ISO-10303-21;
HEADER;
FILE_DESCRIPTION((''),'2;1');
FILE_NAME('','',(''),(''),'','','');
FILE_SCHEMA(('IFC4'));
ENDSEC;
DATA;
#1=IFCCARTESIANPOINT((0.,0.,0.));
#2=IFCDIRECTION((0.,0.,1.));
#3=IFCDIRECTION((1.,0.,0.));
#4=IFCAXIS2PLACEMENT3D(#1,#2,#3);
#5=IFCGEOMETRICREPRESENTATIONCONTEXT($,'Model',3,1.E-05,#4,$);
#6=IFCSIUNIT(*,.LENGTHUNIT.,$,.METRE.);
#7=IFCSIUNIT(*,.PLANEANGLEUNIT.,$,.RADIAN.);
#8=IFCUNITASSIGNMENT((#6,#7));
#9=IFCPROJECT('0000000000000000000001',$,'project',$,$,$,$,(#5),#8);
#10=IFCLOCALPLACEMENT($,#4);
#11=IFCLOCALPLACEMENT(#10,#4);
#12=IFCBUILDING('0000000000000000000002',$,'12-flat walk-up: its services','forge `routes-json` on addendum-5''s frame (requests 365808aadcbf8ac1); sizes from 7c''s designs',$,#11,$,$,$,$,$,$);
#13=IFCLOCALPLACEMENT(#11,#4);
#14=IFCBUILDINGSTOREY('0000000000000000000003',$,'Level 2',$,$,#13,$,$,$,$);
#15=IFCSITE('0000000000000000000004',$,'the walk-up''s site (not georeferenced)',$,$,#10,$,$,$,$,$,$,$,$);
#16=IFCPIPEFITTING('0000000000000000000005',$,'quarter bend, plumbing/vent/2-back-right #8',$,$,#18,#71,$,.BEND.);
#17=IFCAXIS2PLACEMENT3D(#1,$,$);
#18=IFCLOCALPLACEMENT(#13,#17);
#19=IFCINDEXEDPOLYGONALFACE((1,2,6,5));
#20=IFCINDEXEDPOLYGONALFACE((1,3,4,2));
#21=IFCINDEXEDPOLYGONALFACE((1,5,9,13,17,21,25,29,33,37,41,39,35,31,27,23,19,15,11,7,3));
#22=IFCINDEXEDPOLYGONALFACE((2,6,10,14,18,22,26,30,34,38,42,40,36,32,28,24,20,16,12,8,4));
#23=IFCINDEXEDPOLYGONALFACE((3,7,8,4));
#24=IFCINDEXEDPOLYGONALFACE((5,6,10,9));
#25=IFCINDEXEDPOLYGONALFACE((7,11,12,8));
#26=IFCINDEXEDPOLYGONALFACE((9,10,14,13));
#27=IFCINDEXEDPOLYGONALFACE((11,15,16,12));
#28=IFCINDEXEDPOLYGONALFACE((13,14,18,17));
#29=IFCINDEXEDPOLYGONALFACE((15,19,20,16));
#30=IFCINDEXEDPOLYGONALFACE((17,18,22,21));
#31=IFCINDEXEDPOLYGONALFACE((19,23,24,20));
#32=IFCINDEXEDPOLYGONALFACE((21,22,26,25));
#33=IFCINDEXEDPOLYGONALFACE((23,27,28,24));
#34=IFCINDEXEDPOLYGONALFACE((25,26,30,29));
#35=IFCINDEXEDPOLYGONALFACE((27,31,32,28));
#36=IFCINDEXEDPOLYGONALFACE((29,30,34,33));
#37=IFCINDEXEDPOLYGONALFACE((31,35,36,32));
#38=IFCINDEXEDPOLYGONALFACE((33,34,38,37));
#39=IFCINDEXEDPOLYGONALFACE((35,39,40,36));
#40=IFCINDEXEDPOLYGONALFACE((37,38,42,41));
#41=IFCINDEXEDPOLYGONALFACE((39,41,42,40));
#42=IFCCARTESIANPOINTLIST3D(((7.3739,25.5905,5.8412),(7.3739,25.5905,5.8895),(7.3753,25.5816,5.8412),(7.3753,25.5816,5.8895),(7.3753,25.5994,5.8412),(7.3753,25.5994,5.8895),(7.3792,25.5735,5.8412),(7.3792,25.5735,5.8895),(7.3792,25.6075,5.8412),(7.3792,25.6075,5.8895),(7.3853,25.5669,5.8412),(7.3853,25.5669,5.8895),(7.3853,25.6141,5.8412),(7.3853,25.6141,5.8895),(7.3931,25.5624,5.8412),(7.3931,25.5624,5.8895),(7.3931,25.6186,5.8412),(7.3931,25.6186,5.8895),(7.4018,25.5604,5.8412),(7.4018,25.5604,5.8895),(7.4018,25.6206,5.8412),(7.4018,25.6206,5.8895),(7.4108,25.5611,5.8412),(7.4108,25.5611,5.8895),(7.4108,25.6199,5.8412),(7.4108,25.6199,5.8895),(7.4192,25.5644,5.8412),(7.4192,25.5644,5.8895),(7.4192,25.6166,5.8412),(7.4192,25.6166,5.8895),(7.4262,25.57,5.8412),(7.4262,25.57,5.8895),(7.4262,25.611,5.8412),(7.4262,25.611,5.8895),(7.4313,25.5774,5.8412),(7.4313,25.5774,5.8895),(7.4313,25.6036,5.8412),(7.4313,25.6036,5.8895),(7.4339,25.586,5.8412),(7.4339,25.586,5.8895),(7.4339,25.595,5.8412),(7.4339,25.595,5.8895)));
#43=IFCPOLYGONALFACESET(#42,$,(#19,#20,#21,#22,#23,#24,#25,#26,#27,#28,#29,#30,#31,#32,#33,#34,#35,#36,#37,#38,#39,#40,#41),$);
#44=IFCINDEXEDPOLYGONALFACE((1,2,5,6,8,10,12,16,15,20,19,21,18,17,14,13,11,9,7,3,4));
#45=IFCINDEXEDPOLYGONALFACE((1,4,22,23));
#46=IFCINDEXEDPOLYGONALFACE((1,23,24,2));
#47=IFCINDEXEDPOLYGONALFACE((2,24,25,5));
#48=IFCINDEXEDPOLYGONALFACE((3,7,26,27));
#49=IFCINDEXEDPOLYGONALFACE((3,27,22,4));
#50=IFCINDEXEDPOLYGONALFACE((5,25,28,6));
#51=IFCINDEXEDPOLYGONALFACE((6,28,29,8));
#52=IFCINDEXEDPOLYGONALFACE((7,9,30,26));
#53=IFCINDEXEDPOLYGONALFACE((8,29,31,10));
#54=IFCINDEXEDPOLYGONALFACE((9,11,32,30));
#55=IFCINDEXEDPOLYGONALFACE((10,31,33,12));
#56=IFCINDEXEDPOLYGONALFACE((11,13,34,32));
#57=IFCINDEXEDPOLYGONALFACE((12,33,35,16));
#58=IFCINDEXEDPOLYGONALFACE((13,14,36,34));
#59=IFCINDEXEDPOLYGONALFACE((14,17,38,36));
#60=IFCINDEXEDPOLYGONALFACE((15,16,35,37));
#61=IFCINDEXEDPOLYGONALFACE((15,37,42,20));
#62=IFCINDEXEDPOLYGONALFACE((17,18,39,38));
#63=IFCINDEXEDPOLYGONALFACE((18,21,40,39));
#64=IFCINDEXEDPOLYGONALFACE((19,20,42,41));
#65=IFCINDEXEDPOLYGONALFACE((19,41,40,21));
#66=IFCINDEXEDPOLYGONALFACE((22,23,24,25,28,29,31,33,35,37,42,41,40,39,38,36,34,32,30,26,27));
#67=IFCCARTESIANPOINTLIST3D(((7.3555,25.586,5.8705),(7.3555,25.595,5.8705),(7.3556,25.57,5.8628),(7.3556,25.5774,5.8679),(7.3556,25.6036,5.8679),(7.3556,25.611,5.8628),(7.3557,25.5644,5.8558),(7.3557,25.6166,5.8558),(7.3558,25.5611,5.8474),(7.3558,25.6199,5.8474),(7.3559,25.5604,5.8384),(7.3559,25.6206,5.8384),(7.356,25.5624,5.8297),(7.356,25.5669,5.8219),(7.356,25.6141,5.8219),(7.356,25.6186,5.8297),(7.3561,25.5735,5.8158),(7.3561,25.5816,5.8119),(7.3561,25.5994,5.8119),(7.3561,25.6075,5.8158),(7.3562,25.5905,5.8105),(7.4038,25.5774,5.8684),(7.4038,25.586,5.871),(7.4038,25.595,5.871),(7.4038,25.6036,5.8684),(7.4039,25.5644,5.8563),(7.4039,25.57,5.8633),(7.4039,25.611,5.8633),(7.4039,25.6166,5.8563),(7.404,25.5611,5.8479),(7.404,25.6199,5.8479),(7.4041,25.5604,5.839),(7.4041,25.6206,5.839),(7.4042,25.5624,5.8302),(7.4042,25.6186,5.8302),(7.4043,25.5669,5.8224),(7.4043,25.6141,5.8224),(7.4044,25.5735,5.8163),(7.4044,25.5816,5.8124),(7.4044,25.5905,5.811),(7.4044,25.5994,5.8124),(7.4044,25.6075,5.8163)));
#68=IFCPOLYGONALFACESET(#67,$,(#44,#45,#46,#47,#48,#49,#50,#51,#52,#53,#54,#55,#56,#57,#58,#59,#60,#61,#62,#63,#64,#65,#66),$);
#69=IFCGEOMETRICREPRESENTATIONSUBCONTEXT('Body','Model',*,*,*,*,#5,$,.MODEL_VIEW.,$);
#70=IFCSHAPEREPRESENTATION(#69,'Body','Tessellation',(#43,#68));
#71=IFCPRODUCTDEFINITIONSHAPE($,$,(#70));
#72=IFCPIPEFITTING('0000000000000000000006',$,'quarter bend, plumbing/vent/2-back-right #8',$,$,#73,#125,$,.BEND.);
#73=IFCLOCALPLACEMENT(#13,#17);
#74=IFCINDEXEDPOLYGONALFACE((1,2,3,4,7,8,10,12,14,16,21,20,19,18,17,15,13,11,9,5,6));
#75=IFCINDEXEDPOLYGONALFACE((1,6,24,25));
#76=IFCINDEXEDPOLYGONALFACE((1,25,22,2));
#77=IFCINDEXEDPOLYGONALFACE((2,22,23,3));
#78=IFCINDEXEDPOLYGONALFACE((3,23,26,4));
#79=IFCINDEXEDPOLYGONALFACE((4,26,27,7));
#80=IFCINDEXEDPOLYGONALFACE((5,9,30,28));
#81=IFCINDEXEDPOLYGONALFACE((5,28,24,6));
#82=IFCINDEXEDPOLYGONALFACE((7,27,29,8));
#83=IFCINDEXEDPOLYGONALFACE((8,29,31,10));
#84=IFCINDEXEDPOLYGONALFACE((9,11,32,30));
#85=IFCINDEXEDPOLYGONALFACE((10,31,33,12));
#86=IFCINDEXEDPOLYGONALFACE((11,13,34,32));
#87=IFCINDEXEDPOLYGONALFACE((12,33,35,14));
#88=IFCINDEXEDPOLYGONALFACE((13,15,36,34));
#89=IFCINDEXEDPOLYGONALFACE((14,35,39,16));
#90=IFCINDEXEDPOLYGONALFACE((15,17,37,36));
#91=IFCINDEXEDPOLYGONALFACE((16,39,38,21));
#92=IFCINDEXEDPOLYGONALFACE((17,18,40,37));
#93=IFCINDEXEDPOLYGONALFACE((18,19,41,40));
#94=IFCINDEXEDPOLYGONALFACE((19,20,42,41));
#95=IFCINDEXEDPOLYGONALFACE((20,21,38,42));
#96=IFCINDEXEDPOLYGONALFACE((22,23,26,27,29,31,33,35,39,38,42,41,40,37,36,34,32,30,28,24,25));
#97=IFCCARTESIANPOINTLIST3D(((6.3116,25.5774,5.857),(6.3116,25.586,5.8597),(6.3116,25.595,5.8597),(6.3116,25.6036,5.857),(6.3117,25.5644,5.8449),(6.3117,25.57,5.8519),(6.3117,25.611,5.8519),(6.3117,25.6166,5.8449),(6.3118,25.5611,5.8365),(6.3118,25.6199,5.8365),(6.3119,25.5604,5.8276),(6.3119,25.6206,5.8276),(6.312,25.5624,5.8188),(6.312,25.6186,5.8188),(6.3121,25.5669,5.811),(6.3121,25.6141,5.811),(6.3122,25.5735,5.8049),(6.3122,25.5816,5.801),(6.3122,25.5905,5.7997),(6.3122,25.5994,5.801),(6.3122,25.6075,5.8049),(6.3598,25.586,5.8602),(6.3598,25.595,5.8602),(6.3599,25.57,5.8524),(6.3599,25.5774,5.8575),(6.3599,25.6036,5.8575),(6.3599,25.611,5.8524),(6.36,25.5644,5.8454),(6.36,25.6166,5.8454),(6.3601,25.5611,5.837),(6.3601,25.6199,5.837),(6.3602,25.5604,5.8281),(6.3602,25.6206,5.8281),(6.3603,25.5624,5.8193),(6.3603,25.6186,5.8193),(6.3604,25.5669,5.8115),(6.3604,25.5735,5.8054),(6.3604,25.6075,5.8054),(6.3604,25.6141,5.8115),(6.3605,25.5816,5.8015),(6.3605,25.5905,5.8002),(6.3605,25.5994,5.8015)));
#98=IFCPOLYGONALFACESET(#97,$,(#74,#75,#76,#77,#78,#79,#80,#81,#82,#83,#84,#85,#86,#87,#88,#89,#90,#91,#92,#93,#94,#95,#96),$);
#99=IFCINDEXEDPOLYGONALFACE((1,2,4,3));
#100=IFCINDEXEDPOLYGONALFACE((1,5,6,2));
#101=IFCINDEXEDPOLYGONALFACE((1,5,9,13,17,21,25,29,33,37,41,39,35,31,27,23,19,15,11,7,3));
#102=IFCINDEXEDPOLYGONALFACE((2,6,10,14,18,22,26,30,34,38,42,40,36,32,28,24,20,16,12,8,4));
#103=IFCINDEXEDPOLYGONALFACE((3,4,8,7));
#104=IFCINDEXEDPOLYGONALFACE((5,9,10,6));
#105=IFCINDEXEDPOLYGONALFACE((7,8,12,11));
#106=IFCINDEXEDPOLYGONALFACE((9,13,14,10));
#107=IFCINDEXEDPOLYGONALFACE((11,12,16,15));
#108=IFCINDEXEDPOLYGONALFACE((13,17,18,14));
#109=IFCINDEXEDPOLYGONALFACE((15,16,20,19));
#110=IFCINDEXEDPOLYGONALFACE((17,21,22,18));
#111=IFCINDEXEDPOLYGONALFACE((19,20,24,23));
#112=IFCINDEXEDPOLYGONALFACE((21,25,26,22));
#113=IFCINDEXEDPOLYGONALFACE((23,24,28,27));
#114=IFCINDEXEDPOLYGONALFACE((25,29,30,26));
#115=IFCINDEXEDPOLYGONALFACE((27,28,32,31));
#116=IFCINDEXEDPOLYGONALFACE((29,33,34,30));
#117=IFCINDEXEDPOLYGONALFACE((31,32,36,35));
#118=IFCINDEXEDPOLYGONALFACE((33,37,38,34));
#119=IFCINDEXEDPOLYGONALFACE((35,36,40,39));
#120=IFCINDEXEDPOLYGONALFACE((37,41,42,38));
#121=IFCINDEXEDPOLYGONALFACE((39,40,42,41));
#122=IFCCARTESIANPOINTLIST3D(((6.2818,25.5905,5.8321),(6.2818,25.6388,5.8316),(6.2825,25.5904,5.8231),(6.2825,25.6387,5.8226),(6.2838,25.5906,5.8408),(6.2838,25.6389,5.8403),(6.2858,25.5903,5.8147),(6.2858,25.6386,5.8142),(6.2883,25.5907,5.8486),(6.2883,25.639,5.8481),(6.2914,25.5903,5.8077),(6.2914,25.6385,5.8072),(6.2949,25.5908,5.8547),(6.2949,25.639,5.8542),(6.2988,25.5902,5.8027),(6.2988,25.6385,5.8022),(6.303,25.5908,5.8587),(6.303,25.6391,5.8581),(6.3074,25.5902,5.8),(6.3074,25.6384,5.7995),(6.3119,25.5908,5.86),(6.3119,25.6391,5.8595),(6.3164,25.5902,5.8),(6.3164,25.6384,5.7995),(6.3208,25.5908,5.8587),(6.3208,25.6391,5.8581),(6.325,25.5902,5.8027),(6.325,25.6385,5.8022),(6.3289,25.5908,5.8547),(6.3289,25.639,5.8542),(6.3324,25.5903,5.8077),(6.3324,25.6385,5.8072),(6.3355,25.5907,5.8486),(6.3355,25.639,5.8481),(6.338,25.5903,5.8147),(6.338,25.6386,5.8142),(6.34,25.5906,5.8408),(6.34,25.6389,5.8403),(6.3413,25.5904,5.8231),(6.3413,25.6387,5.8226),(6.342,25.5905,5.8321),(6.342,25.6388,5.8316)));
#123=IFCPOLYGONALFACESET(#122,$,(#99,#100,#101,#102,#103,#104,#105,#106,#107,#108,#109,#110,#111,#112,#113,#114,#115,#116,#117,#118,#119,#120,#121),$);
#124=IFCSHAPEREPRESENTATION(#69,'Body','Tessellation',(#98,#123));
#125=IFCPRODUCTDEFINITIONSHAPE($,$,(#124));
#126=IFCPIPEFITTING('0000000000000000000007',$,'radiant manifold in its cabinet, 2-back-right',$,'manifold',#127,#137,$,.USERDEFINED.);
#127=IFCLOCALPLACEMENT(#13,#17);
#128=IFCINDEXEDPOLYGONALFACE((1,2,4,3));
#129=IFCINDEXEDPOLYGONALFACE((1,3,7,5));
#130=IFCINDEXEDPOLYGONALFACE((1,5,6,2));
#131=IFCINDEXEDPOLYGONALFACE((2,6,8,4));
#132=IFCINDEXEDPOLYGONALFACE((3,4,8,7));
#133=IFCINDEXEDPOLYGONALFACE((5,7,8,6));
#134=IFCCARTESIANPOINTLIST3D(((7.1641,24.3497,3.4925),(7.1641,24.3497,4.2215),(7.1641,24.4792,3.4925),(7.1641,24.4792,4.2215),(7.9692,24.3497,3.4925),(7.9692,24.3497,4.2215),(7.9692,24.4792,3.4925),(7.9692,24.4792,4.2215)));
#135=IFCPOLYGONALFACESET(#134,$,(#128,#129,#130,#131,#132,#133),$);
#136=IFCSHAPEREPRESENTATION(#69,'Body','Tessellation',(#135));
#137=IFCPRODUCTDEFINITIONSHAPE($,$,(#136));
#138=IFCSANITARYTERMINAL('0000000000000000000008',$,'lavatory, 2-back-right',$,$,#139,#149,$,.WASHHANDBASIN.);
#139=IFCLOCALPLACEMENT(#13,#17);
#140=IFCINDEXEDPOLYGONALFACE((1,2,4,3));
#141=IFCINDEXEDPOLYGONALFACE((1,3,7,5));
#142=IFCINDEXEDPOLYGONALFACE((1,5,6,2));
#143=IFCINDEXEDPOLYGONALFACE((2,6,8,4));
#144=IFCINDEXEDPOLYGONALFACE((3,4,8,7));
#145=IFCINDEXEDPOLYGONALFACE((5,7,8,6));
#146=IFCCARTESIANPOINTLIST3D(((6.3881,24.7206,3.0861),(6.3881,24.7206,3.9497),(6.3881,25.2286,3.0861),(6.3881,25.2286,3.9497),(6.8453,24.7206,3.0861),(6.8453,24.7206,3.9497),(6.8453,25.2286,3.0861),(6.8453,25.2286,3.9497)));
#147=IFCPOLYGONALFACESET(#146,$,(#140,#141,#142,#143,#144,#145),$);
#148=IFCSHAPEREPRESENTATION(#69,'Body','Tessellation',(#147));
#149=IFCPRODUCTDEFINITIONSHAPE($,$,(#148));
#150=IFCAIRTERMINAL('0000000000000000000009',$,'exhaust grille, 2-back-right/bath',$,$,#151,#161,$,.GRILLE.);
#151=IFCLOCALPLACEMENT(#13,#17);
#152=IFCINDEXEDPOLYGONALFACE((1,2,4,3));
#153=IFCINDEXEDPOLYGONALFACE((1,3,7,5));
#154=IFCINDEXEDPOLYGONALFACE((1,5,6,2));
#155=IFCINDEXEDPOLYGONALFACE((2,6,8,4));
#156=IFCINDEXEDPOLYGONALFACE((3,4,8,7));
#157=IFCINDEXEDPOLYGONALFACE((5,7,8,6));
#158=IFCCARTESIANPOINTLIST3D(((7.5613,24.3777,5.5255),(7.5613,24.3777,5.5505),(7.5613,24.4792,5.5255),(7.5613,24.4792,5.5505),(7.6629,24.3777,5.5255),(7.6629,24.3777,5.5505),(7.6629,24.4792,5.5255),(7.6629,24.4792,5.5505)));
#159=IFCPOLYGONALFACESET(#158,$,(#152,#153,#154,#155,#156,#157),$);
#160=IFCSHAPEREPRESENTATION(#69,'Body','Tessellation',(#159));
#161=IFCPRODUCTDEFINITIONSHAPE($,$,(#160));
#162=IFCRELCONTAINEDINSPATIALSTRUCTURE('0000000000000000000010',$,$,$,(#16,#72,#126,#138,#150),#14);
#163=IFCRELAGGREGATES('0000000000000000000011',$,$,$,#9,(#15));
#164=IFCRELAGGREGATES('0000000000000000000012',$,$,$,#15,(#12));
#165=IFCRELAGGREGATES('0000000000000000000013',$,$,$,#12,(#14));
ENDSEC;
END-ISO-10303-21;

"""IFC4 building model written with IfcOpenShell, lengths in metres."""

from ifc_helpers import new_model, entity, si_unit, frame, frame_2d, origin, origin_with_axes, place, context, subcontext, project, spatial, rectangle, extrude, element, save


model = new_model("IFC4")

# Units and contexts
model_context = context("Model", 3, precision=1e-05, world=origin_with_axes())
body_context = subcontext(model_context, "Body", "Model", "MODEL_VIEW")
ifc_project = project(units=[si_unit("LENGTHUNIT", "METRE"), si_unit("PLANEANGLEUNIT", "RADIAN")], contexts=[model_context])

# Site, building, storey
site_placement = place(None, origin_with_axes())
site = spatial("IfcSite", under=ifc_project, at=site_placement, Name="the walk-up's site (not georeferenced)")
building_placement = place(site_placement, origin_with_axes())
building = spatial("IfcBuilding", under=site, at=building_placement, Name="12-flat walk-up: its services", Description="forge `routes-json` on addendum-5's frame (requests 365808aadcbf8ac1); sizes from 7c's designs")
storey_placement = place(building_placement, origin_with_axes())
storey = spatial("IfcBuildingStorey", under=building, at=storey_placement, Name="Level 2")

# Pipe fittings
pipe_fitting_1_placement = place(storey_placement, frame((7.4041, 25.5905, 5.8895), z_axis=(0.0, 0.0, 1.0), x_axis=(1.0, 0.0, 0.0)))
element("IfcPipeFitting", 1, at=pipe_fitting_1_placement, inside=storey, Name="quarter bend, plumbing/vent/2-back-right #8", PredefinedType="BEND", context=body_context, shape_type="AdvancedSweptSolid", body=[
    entity("IfcSweptDiskSolid", entity("IfcPolyline", [entity("IfcCartesianPoint", [0.0, 0.0, 0.0]), entity("IfcCartesianPoint", [0.0, 0.0, -0.0483])]), 0.0302),
    entity("IfcSweptDiskSolid", entity("IfcPolyline", [entity("IfcCartesianPoint", [0.0, 0.0, -0.0483]), entity("IfcCartesianPoint", [-0.0483, 0.0, -0.0488])]), 0.0302),
])
pipe_fitting_2_placement = place(storey_placement, frame((6.3602, 25.5905, 5.8303), z_axis=(0.0, 0.0, 1.0), x_axis=(1.0, 0.0, 0.0)))
element("IfcPipeFitting", 2, at=pipe_fitting_2_placement, inside=storey, Name="quarter bend, plumbing/vent/2-back-right #8", PredefinedType="BEND", context=body_context, shape_type="AdvancedSweptSolid", body=[
    entity("IfcSweptDiskSolid", entity("IfcPolyline", [entity("IfcCartesianPoint", [0.0, 0.0, 0.0]), entity("IfcCartesianPoint", [-0.0483, 0.0, -0.0005])]), 0.0302),
    entity("IfcSweptDiskSolid", entity("IfcPolyline", [entity("IfcCartesianPoint", [-0.0483, 0.0, -0.0005]), entity("IfcCartesianPoint", [-0.0483, 0.0483, -0.001])]), 0.0302),
])
pipe_fitting_3_placement = place(storey_placement, frame((7.1641, 24.3497, 3.4925), z_axis=(0.0, 0.0, 1.0), x_axis=(1.0, 0.0, 0.0)))
element("IfcPipeFitting", 3, at=pipe_fitting_3_placement, inside=storey, Name="radiant manifold in its cabinet, 2-back-right", ObjectType="manifold", PredefinedType="USERDEFINED", context=body_context, shape_type="SweptSolid", body=[
    extrude(rectangle(XDim=0.8052, YDim=0.1295, at=frame_2d((0.4026, 0.0648))), origin(), (0.0, 0.0, 1.0), 0.729),
])

# Sanitary terminal
sanitary_terminal_placement = place(storey_placement, frame((6.3881, 24.7205, 3.0861), z_axis=(0.0, 0.0, 1.0), x_axis=(1.0, 0.0, 0.0)))
element("IfcSanitaryTerminal", 4, at=sanitary_terminal_placement, inside=storey, Name="lavatory, 2-back-right", PredefinedType="WASHHANDBASIN", context=body_context, shape_type="SweptSolid", body=[
    extrude(rectangle(XDim=0.4572, YDim=0.508, at=frame_2d((0.2286, 0.254))), origin(), (0.0, 0.0, 1.0), 0.8636),
])

# Air terminal
air_terminal_placement = place(storey_placement, frame((7.5613, 24.3777, 5.5255), z_axis=(0.0, 0.0, 1.0), x_axis=(1.0, 0.0, 0.0)))
element("IfcAirTerminal", 5, at=air_terminal_placement, inside=storey, Name="exhaust grille, 2-back-right/bath", PredefinedType="GRILLE", context=body_context, shape_type="SweptSolid", body=[
    extrude(rectangle(XDim=0.1016, YDim=0.1016, at=frame_2d((0.0508, 0.0508))), origin(), (0.0, 0.0, 1.0), 0.025),
])

save(model, "model.ifc")
